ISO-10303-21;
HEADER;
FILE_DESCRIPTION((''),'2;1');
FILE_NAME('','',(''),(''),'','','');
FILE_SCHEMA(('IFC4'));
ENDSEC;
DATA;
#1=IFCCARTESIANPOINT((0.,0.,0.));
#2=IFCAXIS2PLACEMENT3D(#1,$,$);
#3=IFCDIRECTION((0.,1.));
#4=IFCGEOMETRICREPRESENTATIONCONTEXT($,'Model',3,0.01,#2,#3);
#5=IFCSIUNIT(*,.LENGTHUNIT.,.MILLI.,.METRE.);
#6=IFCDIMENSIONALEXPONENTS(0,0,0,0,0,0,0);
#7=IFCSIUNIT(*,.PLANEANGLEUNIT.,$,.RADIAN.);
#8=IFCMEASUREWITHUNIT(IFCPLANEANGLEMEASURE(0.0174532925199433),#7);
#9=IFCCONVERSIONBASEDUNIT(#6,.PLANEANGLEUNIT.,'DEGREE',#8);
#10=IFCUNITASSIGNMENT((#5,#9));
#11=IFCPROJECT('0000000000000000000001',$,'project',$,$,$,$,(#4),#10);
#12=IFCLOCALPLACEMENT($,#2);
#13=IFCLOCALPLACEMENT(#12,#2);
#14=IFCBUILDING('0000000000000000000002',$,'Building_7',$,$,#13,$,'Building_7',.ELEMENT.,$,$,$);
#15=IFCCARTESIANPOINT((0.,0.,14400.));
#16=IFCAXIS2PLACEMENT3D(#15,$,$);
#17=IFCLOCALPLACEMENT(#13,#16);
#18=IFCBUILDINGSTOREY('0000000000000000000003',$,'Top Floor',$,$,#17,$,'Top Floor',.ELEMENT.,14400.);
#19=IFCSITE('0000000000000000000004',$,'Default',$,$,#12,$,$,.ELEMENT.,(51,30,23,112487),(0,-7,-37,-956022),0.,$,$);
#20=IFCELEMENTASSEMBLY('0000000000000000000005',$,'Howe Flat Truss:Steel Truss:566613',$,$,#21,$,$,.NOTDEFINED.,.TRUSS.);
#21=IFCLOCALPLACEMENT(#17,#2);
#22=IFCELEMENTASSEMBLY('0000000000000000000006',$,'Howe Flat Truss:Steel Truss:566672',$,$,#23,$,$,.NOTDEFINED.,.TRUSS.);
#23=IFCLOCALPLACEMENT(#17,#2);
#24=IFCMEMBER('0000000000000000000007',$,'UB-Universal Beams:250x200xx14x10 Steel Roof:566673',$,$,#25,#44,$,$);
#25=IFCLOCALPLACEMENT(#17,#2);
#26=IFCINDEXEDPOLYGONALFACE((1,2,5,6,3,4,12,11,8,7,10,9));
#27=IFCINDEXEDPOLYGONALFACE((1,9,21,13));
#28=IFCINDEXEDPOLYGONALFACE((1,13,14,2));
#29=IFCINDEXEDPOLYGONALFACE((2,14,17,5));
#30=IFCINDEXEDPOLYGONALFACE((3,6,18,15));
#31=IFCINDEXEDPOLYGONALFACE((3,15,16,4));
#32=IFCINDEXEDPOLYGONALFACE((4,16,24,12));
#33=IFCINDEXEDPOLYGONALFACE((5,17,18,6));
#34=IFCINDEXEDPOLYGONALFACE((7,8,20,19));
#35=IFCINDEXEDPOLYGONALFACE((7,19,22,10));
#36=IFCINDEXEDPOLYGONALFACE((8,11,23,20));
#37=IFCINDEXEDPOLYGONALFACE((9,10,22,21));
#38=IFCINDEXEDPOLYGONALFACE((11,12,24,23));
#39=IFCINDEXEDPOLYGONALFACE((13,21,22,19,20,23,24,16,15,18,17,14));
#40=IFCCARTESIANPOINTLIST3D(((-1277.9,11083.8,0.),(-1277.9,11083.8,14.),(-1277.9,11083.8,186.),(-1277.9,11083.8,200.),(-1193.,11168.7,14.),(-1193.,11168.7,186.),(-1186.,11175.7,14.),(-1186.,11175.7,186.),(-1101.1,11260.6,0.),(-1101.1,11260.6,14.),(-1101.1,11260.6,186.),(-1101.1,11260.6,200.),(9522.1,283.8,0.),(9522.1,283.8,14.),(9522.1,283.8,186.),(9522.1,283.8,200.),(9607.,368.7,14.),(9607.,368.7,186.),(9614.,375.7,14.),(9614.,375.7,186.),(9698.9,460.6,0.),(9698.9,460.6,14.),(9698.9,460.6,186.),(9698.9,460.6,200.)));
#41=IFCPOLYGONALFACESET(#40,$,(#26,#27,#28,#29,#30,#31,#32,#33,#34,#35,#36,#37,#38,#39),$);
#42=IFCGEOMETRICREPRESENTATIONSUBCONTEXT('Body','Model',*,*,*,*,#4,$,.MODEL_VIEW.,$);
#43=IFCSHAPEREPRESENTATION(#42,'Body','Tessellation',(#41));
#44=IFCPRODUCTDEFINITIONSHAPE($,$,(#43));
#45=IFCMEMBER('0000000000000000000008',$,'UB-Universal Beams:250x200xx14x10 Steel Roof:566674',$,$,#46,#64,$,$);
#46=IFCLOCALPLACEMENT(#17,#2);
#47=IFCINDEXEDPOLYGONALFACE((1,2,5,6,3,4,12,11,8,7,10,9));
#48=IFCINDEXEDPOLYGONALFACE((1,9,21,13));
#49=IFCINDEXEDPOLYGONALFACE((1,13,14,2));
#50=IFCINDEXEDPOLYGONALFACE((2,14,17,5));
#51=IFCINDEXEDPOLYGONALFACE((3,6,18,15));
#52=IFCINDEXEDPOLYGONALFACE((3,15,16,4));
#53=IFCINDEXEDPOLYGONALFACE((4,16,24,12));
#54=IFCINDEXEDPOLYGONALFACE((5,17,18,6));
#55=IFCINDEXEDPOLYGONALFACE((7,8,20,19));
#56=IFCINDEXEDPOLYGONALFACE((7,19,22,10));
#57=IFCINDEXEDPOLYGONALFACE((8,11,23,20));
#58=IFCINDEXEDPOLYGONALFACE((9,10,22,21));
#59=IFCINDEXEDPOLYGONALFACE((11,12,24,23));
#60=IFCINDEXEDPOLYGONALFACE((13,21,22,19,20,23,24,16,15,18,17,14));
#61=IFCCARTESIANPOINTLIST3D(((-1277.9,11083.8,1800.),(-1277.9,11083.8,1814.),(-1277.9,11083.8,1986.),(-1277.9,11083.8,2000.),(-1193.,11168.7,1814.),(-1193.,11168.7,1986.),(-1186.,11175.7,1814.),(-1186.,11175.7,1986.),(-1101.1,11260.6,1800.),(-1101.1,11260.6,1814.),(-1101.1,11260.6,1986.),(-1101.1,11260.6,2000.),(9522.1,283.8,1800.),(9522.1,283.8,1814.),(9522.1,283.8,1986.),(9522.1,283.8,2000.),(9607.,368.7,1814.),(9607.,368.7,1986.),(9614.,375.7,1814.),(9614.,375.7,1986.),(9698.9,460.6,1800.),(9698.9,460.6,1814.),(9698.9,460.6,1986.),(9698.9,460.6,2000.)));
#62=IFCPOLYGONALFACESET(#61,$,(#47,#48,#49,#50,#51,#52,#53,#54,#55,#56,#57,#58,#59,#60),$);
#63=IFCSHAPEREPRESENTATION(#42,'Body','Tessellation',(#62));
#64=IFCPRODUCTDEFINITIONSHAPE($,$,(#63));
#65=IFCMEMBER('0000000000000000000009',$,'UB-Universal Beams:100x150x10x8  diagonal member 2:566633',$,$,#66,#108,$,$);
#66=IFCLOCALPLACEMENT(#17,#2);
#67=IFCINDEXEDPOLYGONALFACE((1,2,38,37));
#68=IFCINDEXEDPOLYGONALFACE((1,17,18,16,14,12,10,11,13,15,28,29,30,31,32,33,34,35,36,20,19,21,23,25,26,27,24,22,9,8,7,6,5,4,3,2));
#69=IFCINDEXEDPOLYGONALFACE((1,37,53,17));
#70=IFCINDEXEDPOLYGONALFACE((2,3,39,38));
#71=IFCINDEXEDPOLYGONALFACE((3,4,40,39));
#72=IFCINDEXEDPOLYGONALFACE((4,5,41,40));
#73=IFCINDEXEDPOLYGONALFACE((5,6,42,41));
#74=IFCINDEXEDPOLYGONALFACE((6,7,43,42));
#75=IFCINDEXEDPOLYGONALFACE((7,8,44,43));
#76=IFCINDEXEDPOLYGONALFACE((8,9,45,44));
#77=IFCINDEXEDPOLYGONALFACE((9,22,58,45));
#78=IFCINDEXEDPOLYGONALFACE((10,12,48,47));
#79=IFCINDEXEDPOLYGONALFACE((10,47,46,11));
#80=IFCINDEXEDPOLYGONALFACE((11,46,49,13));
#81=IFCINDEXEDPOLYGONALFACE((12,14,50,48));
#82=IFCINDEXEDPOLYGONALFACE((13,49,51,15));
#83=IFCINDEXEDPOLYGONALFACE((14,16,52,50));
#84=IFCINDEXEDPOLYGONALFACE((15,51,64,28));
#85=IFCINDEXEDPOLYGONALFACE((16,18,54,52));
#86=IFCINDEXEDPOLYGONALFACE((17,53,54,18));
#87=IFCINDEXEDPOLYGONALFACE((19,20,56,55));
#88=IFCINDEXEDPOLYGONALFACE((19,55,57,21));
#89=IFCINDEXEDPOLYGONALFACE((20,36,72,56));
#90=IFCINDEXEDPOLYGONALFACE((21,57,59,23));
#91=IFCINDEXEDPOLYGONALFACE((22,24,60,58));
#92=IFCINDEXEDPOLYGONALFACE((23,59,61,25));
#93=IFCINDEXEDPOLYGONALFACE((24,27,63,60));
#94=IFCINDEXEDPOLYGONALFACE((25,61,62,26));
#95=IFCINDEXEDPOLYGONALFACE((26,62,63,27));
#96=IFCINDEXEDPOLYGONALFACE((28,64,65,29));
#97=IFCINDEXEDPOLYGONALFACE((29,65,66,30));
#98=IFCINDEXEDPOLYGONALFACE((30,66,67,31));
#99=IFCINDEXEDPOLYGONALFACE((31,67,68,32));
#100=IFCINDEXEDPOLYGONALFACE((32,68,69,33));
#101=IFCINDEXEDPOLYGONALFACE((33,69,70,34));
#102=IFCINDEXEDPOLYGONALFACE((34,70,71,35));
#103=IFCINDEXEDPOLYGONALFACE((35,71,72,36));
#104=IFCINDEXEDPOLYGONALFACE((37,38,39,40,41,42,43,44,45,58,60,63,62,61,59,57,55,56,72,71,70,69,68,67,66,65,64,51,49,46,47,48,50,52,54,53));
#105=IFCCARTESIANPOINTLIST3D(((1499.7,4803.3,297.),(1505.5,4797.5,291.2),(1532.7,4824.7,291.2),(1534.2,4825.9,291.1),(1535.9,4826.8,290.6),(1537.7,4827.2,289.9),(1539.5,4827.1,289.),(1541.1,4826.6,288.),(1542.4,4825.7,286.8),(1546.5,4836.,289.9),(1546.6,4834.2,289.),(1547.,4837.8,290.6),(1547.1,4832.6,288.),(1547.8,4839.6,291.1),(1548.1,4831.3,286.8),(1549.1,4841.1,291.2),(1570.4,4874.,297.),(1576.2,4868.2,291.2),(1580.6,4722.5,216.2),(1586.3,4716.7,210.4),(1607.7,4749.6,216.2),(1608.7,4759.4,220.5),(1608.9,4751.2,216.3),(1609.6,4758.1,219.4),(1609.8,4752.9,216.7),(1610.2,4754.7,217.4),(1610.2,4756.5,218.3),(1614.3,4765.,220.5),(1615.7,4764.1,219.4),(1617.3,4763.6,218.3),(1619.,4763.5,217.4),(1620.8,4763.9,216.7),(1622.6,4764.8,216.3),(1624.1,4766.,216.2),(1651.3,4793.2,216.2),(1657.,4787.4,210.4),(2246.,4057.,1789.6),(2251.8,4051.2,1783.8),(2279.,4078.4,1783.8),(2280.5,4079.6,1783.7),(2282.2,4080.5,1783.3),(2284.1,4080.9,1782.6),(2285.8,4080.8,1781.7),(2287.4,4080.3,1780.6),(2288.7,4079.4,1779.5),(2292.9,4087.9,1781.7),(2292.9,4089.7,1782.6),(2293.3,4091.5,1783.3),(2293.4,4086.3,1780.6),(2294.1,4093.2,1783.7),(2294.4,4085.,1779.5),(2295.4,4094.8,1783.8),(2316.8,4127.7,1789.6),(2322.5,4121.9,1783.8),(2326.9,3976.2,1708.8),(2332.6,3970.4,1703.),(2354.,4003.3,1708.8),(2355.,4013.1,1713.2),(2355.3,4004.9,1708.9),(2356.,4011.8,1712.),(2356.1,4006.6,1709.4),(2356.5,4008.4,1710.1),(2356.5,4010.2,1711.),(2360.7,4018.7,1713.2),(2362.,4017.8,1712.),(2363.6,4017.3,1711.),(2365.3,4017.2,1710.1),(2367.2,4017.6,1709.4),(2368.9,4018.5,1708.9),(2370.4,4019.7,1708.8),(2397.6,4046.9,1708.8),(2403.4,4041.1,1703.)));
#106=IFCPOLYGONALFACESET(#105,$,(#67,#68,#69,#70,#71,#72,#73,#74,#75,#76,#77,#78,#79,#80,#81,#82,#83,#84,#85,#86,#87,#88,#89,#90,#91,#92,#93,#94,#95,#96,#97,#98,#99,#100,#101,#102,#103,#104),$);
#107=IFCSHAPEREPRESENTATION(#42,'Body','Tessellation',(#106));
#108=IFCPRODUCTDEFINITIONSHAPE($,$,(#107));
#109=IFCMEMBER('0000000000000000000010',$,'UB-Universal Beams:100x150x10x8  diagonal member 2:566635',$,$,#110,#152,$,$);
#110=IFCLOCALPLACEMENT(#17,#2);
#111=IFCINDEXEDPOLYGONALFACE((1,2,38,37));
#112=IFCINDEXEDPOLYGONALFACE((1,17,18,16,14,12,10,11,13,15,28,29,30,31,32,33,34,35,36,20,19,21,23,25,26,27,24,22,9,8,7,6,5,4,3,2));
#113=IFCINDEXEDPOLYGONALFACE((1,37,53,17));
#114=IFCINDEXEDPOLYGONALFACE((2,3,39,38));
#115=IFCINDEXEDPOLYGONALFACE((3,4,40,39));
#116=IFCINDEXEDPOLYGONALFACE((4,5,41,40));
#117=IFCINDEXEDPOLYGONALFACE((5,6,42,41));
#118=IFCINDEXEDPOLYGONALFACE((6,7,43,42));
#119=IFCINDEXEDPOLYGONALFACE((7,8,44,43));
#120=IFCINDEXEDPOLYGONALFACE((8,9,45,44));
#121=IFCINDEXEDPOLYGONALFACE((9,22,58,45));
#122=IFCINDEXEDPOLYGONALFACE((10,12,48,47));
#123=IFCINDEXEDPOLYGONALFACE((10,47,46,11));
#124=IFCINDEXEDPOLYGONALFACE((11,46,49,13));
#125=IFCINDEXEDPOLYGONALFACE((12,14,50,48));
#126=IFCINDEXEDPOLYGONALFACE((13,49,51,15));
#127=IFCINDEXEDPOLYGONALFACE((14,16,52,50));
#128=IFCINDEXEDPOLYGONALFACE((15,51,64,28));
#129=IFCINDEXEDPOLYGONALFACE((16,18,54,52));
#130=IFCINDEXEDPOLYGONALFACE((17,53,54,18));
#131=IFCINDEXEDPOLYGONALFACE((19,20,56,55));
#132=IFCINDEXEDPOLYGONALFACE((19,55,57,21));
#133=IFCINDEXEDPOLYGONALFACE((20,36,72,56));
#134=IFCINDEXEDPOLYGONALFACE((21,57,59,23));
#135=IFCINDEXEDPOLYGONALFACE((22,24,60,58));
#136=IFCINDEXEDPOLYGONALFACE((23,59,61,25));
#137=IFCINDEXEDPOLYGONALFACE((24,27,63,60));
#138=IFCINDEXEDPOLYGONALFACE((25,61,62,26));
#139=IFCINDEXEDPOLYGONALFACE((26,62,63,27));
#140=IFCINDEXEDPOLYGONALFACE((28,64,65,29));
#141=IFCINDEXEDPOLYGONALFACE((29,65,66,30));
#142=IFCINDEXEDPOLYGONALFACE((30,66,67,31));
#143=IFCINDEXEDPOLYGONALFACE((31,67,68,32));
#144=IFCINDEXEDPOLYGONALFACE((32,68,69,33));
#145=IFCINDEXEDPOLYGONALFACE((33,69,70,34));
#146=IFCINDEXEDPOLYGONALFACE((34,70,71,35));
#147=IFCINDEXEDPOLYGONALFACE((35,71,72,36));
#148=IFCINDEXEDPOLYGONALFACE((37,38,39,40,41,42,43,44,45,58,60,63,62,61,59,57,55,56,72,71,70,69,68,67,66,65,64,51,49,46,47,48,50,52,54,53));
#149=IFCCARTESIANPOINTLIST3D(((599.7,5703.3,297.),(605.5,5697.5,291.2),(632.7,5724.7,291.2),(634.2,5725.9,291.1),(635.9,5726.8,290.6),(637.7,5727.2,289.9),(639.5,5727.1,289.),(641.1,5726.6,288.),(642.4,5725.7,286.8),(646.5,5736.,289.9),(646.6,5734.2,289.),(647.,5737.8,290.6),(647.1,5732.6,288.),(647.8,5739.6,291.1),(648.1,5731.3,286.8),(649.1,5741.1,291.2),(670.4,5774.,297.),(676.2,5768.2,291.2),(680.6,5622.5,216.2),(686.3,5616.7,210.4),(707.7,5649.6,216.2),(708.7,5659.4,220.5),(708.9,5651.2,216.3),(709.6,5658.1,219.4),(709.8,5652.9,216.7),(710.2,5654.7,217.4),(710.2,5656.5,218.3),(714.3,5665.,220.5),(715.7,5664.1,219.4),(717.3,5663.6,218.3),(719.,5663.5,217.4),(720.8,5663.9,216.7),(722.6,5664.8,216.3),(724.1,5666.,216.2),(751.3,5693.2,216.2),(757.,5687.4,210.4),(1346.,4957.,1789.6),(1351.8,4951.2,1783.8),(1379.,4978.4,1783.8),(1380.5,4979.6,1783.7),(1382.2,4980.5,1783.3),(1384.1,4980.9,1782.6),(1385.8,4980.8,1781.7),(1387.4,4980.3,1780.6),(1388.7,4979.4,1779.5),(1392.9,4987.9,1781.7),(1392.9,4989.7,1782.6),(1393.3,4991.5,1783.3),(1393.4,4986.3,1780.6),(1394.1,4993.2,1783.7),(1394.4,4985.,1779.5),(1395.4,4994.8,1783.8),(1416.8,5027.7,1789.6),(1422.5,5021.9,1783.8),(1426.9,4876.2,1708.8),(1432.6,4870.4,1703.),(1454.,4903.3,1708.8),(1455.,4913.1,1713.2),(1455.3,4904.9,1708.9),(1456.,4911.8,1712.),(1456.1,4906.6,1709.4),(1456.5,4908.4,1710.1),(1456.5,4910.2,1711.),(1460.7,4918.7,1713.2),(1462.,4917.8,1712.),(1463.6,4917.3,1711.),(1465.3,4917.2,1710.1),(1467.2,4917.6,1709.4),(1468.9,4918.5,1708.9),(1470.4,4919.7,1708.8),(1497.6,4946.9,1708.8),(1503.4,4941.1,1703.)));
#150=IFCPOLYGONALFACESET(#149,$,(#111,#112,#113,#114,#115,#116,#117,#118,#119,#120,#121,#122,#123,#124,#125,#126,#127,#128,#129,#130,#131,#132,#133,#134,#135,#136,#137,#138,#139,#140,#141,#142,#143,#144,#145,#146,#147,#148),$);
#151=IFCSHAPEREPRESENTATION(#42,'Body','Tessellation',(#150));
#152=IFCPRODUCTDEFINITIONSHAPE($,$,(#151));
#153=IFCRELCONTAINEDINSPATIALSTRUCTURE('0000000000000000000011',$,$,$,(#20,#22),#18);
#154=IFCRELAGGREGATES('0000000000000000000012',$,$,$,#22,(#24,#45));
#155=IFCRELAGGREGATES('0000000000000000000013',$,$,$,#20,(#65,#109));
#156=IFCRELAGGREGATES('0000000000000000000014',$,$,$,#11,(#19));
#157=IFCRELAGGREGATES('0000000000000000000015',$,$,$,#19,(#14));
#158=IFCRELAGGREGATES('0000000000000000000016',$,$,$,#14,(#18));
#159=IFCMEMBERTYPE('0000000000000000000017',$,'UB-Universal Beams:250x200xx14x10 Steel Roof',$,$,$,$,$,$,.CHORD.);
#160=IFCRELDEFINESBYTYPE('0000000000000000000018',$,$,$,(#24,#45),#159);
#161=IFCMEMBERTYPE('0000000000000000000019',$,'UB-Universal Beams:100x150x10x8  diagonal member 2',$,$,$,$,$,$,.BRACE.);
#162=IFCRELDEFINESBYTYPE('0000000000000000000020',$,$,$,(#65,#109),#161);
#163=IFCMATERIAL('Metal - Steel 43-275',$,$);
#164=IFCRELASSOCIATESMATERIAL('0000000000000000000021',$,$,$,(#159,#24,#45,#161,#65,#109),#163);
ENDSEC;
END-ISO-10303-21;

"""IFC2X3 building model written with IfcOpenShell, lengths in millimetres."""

from ifc_helpers import new_model, entity, si_unit, converted_unit, direction, frame, frame_2d, origin, place, context, subcontext, project, spatial, polyline, circle_curve, parameter, trimmed, segment, composite_curve, outline, extrude, source, transform, mapped, material, type_object, type_shapes, element, aggregate, save


model = new_model("IFC2X3")

# Units and contexts
model_context = context("Model", 3, precision=0.01, world=origin(), true_north=direction((0.0, 1.0)))
body_context = subcontext(model_context, "Body", "Model", "MODEL_VIEW")
ifc_project = project(units=[si_unit("LENGTHUNIT", "METRE", prefix="MILLI"), converted_unit("PLANEANGLEUNIT", "DEGREE", entity("IfcPlaneAngleMeasure", 0.0174532925199433), si_unit("PLANEANGLEUNIT", "RADIAN"), dimensions=[0, 0, 0, 0, 0, 0, 0])], contexts=[model_context])

# Site, building, storey
site_placement = place(None, origin())
site = spatial("IfcSite", under=ifc_project, at=site_placement, Name="Default", CompositionType="ELEMENT", RefLatitude=(51, 30, 23, 112487), RefLongitude=(0, -7, -37, -956022), RefElevation=0.0)
building_placement = place(site_placement, origin())
building = spatial("IfcBuilding", under=site, at=building_placement, Name="Building_7", LongName="Building_7", CompositionType="ELEMENT")
storey_placement = place(building_placement, frame((0.0, 0.0, 14400.0)))
storey = spatial("IfcBuildingStorey", under=building, at=storey_placement, Name="Top Floor", LongName="Top Floor", CompositionType="ELEMENT", Elevation=14400.0)

# Shared definitions
ifc_material = material(Name="Metal - Steel 43-275")

# Element assemblies
assembly_1_placement = place(storey_placement, origin())
assembly_1 = element("IfcElementAssembly", 1, at=assembly_1_placement, inside=storey, Name="Howe Flat Truss:Steel Truss:566613", AssemblyPlace="NOTDEFINED", PredefinedType="TRUSS")
assembly_2_placement = place(storey_placement, origin())
assembly_2 = element("IfcElementAssembly", 2, at=assembly_2_placement, inside=storey, Name="Howe Flat Truss:Steel Truss:566672", AssemblyPlace="NOTDEFINED", PredefinedType="TRUSS")

# Members
member_type_1 = type_object("IfcMemberType", Name="UB-Universal Beams:250x200xx14x10 Steel Roof", PredefinedType="CHORD", material=ifc_material)
shared_shape_1 = source(origin(), body_context, "Body", "SweptSolid", [
    extrude(outline(polyline([(-125.0, -86.0), (-125.0, -100.0), (125.0, -100.0), (125.0, -86.0), (5.0, -86.0), (5.0, 86.0), (125.0, 86.0), (125.0, 100.0), (-125.0, 100.0), (-125.0, 86.0), (-5.0, 86.0), (-5.0, -86.0), (-125.0, -86.0)])), frame((-7636.8, 0.0, 0.0), z_axis=(-1.0, 0.0, 0.0), x_axis=(0.0, -1.0, 0.0)), (0.0, 0.0, -1.0), 15273.5),
])
type_shapes(member_type_1, [shared_shape_1])
member_1_placement = place(assembly_2_placement, frame((4210.5, 5772.2, 100.0), z_axis=(0.0, 0.0, 1.0), x_axis=(-0.707107, 0.707107, 0.0)))
member_1 = element("IfcMember", 3, at=member_1_placement, type_object=member_type_1, material=ifc_material, Name="UB-Universal Beams:250x200xx14x10 Steel Roof:566673", context=body_context, shape_type="MappedRepresentation", body=[
    mapped(shared_shape_1, transform((0.0, 0.0, 0.0), scale=1.0)),
])
member_2_placement = place(assembly_2_placement, frame((4210.5, 5772.2, 1900.0), z_axis=(0.0, 0.0, 1.0), x_axis=(-0.707107, 0.707107, 0.0)))
member_2 = element("IfcMember", 4, at=member_2_placement, type_object=member_type_1, material=ifc_material, Name="UB-Universal Beams:250x200xx14x10 Steel Roof:566674", context=body_context, shape_type="MappedRepresentation", body=[
    mapped(shared_shape_1, transform((0.0, 0.0, 0.0), scale=1.0)),
])
member_type_2 = type_object("IfcMemberType", Name="UB-Universal Beams:100x150x10x8  diagonal member 2", PredefinedType="BRACE", material=ifc_material)
shared_shape_2 = source(origin(), body_context, "Body", "SweptSolid", [
    extrude(outline(composite_curve([segment(polyline([(-50.0, -65.0), (-50.0, -75.0)]), True, "CONTINUOUS"), segment(polyline([(-50.0, -75.0), (50.0, -75.0)]), True, "CONTINUOUS"), segment(polyline([(50.0, -75.0), (50.0, -65.0)]), True, "CONTINUOUS"), segment(polyline([(50.0, -65.0), (11.6, -65.0)]), True, "CONTINUOUS"), segment(trimmed(circle_curve(frame_2d((11.6, -57.4), x_axis=(1.0, 0.0)), 7.6), [parameter(180.0)], [parameter(270.0)], True, "PARAMETER"), False, "CONTINUOUS"), segment(polyline([(4.0, -57.4), (4.0, 57.4)]), True, "CONTINUOUS"), segment(trimmed(circle_curve(frame_2d((11.6, 57.4), x_axis=(1.0, 0.0)), 7.6), [parameter(90.0)], [parameter(180.0)], True, "PARAMETER"), False, "CONTINUOUS"), segment(polyline([(11.6, 65.0), (50.0, 65.0)]), True, "CONTINUOUS"), segment(polyline([(50.0, 65.0), (50.0, 75.0)]), True, "CONTINUOUS"), segment(polyline([(50.0, 75.0), (-50.0, 75.0)]), True, "CONTINUOUS"), segment(polyline([(-50.0, 75.0), (-50.0, 65.0)]), True, "CONTINUOUS"), segment(polyline([(-50.0, 65.0), (-11.6, 65.0)]), True, "CONTINUOUS"), segment(trimmed(circle_curve(frame_2d((-11.6, 57.4), x_axis=(1.0, 0.0)), 7.6), [parameter(360.0)], [parameter(90.0)], True, "PARAMETER"), False, "CONTINUOUS"), segment(polyline([(-4.0, 57.4), (-4.0, -57.4)]), True, "CONTINUOUS"), segment(trimmed(circle_curve(frame_2d((-11.6, -57.4), x_axis=(1.0, 0.0)), 7.6), [parameter(270.0)], [parameter(360.0)], True, "PARAMETER"), False, "CONTINUOUS"), segment(polyline([(-11.6, -65.0), (-50.0, -65.0)]), True, "CONTINUOUS")], self_intersect=False)), frame((-914.0, 0.0, 0.0), z_axis=(-1.0, 0.0, 0.0), x_axis=(0.0, -1.0, 0.0)), (0.0, 0.0, -1.0), 1828.1),
])
type_shapes(member_type_2, [shared_shape_2])
member_3_placement = place(assembly_1_placement, frame((1951.5, 4422.2, 1000.0), z_axis=(0.57735, -0.57735, -0.57735), x_axis=(0.408248, -0.408248, 0.816497)))
member_3 = element("IfcMember", 5, at=member_3_placement, type_object=member_type_2, material=ifc_material, Name="UB-Universal Beams:100x150x10x8  diagonal member 2:566633", context=body_context, shape_type="MappedRepresentation", body=[
    mapped(shared_shape_2, transform((0.0, 0.0, 0.0), scale=1.0)),
])
member_4_placement = place(assembly_1_placement, frame((1051.5, 5322.2, 1000.0), z_axis=(0.57735, -0.57735, -0.57735), x_axis=(0.408248, -0.408248, 0.816497)))
member_4 = element("IfcMember", 6, at=member_4_placement, type_object=member_type_2, material=ifc_material, Name="UB-Universal Beams:100x150x10x8  diagonal member 2:566635", context=body_context, shape_type="MappedRepresentation", body=[
    mapped(shared_shape_2, transform((0.0, 0.0, 0.0), scale=1.0)),
])
aggregate(assembly_2, [member_1, member_2])
aggregate(assembly_1, [member_3, member_4])

save(model, "model.ifc")
